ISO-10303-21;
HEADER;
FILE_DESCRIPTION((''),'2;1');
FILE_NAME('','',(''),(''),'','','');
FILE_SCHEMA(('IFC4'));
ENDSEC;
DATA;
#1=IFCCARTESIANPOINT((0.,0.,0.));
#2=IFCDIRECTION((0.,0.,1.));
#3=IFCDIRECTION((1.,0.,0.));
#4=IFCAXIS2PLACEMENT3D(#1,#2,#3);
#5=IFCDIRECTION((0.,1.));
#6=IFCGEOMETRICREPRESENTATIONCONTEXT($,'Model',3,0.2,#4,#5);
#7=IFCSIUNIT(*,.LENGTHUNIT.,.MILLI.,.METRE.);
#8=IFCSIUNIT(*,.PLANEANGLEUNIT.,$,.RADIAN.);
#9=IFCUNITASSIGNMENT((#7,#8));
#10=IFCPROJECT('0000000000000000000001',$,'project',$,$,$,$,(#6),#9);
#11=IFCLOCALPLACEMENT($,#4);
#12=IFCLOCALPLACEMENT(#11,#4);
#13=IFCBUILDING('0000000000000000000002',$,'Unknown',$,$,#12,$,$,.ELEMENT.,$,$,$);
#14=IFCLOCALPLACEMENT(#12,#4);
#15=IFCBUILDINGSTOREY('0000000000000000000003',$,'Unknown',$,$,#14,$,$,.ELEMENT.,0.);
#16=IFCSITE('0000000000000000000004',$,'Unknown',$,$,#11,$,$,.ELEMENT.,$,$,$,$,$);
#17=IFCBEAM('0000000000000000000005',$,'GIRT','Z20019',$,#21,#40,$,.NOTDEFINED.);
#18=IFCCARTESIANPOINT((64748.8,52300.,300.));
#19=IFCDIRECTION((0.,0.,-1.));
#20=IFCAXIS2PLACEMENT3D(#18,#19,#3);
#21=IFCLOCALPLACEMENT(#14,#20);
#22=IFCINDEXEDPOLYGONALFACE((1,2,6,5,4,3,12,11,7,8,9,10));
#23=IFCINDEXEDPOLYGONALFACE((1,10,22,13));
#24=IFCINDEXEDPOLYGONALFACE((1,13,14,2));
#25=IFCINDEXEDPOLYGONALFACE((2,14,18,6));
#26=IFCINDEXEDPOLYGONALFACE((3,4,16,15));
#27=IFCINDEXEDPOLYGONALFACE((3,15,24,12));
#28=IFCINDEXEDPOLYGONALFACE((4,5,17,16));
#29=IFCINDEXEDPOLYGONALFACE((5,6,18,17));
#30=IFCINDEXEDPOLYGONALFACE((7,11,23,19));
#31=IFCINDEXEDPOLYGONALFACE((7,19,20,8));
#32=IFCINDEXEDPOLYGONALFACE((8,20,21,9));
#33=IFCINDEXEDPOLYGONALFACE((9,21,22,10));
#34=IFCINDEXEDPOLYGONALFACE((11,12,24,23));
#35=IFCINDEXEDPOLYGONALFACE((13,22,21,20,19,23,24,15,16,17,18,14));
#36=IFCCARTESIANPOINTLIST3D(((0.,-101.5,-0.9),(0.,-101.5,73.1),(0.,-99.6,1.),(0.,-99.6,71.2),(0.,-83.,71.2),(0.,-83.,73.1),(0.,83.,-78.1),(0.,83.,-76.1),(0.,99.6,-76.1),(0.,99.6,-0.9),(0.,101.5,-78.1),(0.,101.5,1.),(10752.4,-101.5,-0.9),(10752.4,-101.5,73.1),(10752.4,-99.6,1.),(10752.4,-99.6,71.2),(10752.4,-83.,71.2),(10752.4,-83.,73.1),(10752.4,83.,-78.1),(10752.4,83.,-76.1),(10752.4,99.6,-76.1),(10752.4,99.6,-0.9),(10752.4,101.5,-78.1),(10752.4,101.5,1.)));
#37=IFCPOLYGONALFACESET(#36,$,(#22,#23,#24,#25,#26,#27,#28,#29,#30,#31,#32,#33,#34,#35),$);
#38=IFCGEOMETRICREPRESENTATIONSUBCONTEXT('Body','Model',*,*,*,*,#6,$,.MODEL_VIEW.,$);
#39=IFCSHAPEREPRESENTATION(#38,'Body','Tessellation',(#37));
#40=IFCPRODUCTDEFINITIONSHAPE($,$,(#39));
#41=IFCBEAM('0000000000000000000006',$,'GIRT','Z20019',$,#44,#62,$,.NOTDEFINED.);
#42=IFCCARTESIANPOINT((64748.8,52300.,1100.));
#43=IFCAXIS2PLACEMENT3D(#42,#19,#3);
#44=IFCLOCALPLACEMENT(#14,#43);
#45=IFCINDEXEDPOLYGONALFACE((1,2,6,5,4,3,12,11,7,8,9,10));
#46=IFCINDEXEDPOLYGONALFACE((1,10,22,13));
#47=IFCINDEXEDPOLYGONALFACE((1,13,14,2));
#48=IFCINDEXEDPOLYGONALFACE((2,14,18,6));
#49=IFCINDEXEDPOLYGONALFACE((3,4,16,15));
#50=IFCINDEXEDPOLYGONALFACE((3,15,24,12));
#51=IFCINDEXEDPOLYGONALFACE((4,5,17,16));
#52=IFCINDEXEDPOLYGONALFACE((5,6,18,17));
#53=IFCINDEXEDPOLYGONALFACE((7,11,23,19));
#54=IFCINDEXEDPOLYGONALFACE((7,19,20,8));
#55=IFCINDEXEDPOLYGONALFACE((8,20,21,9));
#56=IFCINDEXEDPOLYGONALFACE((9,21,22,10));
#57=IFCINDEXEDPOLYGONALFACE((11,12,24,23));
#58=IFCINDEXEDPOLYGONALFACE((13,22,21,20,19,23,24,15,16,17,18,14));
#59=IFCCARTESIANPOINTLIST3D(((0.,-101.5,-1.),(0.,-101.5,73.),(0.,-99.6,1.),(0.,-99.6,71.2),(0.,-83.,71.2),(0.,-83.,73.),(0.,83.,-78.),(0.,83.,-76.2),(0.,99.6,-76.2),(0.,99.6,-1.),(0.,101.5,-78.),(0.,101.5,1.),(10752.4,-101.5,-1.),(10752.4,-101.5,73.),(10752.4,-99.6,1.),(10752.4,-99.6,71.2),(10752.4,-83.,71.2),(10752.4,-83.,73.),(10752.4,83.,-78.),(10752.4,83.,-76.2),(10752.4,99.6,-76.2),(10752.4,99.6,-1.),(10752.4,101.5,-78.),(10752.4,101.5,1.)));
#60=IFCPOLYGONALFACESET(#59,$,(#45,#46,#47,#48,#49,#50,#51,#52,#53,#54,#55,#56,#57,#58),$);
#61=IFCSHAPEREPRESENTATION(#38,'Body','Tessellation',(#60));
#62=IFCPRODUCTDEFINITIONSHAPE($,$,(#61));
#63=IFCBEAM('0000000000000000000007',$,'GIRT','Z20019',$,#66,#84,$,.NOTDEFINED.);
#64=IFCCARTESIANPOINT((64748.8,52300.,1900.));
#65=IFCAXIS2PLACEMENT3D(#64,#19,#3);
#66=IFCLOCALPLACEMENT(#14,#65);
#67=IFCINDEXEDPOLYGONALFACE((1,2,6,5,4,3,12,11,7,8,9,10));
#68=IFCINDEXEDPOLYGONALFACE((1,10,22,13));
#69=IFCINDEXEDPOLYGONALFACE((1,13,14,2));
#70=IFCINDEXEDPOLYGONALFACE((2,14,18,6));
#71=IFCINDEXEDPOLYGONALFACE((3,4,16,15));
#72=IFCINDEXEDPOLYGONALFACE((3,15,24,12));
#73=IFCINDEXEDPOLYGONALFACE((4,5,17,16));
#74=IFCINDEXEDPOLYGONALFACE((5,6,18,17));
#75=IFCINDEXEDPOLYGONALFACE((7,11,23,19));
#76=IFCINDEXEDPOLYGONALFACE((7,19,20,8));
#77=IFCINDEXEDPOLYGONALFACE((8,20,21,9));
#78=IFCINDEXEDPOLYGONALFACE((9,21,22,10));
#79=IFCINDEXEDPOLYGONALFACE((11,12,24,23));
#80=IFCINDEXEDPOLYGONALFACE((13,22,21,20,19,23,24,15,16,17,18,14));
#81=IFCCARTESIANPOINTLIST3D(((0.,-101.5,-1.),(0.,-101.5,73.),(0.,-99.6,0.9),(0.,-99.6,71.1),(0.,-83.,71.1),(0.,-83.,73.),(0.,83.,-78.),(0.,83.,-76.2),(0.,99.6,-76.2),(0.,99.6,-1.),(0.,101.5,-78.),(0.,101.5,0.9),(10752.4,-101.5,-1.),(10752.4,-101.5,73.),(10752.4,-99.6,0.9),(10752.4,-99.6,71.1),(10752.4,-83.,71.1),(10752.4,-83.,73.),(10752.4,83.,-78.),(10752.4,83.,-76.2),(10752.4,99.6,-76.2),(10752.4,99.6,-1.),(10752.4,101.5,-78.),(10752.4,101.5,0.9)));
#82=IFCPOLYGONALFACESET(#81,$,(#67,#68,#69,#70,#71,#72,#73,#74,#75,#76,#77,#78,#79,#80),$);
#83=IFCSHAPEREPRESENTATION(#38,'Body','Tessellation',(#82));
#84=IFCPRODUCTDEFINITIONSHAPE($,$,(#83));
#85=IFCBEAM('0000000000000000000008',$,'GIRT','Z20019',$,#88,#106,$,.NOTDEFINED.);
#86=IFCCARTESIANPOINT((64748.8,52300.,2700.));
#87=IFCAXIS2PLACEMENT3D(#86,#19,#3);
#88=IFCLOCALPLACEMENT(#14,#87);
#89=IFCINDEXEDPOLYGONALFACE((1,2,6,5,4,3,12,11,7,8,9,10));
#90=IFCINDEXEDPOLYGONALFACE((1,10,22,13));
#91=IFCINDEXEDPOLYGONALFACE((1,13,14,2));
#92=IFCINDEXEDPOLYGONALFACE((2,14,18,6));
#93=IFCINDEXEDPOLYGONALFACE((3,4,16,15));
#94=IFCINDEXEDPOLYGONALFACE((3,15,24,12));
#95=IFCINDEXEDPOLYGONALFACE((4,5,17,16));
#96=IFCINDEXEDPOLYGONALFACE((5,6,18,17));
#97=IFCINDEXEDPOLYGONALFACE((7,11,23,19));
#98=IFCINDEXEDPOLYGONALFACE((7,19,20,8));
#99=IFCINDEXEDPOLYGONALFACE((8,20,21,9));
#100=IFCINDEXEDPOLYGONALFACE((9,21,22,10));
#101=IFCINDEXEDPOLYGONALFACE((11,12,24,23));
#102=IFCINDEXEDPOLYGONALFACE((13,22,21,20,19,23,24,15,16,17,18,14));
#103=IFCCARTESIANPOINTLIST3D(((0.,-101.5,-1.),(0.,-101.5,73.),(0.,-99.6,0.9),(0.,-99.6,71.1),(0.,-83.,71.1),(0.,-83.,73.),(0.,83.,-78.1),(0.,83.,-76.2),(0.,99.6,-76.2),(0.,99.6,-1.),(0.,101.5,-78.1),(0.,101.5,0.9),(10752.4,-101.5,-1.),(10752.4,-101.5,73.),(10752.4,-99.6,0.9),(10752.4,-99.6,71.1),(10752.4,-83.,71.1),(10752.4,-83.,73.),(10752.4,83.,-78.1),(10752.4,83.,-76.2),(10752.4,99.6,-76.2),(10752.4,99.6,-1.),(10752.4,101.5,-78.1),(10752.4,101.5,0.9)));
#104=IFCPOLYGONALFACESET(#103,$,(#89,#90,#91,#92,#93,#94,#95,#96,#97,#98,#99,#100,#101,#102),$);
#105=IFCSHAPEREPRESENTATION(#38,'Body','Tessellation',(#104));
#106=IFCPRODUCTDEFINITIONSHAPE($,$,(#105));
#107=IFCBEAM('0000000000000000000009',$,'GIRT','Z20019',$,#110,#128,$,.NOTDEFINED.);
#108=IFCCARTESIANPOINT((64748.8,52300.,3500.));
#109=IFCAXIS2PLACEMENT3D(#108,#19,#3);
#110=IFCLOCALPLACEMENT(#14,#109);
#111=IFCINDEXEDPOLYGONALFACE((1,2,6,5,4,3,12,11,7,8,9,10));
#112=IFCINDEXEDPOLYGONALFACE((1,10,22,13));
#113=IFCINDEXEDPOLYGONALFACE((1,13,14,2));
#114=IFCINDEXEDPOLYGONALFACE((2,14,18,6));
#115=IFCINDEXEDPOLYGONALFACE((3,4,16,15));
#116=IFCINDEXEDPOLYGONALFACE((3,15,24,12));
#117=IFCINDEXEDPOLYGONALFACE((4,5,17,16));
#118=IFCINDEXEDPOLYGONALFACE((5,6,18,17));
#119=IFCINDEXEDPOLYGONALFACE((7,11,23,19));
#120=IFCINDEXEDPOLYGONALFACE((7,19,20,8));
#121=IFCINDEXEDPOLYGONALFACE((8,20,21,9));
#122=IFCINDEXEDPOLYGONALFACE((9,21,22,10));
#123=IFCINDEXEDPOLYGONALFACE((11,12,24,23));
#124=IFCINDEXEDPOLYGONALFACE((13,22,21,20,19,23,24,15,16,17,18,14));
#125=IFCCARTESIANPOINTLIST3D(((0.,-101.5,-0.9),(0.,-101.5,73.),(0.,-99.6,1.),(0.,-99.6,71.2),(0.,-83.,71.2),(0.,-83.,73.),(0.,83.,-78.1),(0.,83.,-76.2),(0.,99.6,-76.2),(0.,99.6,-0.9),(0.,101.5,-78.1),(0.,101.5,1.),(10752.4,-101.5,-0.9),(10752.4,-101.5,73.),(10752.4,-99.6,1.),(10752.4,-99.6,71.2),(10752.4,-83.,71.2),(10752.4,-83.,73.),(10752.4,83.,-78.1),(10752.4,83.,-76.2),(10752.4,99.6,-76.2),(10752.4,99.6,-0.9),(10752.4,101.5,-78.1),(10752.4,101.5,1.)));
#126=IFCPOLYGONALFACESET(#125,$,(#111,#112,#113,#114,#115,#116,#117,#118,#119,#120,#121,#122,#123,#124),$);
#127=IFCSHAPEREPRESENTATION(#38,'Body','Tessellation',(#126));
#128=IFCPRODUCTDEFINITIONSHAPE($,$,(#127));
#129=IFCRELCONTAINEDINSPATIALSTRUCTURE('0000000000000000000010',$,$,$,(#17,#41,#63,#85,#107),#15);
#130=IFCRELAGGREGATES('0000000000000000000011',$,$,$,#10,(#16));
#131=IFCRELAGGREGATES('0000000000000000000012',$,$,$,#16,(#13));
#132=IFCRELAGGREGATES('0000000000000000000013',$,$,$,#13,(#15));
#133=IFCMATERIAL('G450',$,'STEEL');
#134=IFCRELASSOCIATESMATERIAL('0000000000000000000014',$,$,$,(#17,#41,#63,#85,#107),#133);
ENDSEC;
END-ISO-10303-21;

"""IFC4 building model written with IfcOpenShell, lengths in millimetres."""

from ifc_helpers import new_model, si_unit, direction, frame, origin_with_axes, place, context, subcontext, project, spatial, line, indexed_curve, outline, extrude, material, element, save


model = new_model("IFC4")

# Units and contexts
model_context = context("Model", 3, precision=0.2, world=origin_with_axes(), true_north=direction((0.0, 1.0)))
body_context = subcontext(model_context, "Body", "Model", "MODEL_VIEW")
ifc_project = project(units=[si_unit("LENGTHUNIT", "METRE", prefix="MILLI"), si_unit("PLANEANGLEUNIT", "RADIAN")], contexts=[model_context])

# Site, building, storey
site_placement = place(None, origin_with_axes())
site = spatial("IfcSite", under=ifc_project, at=site_placement, Name="Unknown", CompositionType="ELEMENT")
building_placement = place(site_placement, origin_with_axes())
building = spatial("IfcBuilding", under=site, at=building_placement, Name="Unknown", CompositionType="ELEMENT")
storey_placement = place(building_placement, origin_with_axes())
storey = spatial("IfcBuildingStorey", under=building, at=storey_placement, Name="Unknown", CompositionType="ELEMENT", Elevation=0.0)

# Shared definitions
ifc_material = material(Name="G450", Category="STEEL")

# Beams
for number, where, z_axis, x_axis, name in (
    (1, (64748.8, 52300.0, 300.0), (0.0, 0.0, -1.0), (1.0, 0.0, 0.0), "GIRT"),
    (2, (64748.8, 52300.0, 1100.0), (0.0, 0.0, -1.0), (1.0, 0.0, 0.0), "GIRT"),
    (3, (64748.8, 52300.0, 1900.0), (0.0, 0.0, -1.0), (1.0, 0.0, 0.0), "GIRT"),
    (4, (64748.8, 52300.0, 2700.0), (0.0, 0.0, -1.0), (1.0, 0.0, 0.0), "GIRT"),
    (5, (64748.8, 52300.0, 3500.0), (0.0, 0.0, -1.0), (1.0, 0.0, 0.0), "GIRT"),
):
    element("IfcBeam", number, at=place(storey_placement, frame(where, z_axis=z_axis, x_axis=x_axis)), inside=storey, material=ifc_material, Name=name, Description="Z20019", PredefinedType="NOTDEFINED", context=body_context, shape_type="SolidModel", body=[
        extrude(outline(indexed_curve([(73.0, -101.5), (73.0, -83.0), (71.2, -83.0), (71.2, -99.6), (0.9, -99.6), (0.9, 101.5), (-78.0, 101.5), (-78.0, 83.0), (-76.2, 83.0), (-76.2, 99.6), (-0.9, 99.6), (-0.9, -101.5)], segments=[line(1, 2, 3, 4, 5, 6, 7, 8, 9, 10, 11, 12, 1)])), frame((0.0, 0.0, 0.0), z_axis=(-1.0, 0.0, 0.0), x_axis=(0.0, 0.0, 1.0)), (0.0, 0.0, -1.0), 10752.4),
    ])

save(model, "model.ifc")
